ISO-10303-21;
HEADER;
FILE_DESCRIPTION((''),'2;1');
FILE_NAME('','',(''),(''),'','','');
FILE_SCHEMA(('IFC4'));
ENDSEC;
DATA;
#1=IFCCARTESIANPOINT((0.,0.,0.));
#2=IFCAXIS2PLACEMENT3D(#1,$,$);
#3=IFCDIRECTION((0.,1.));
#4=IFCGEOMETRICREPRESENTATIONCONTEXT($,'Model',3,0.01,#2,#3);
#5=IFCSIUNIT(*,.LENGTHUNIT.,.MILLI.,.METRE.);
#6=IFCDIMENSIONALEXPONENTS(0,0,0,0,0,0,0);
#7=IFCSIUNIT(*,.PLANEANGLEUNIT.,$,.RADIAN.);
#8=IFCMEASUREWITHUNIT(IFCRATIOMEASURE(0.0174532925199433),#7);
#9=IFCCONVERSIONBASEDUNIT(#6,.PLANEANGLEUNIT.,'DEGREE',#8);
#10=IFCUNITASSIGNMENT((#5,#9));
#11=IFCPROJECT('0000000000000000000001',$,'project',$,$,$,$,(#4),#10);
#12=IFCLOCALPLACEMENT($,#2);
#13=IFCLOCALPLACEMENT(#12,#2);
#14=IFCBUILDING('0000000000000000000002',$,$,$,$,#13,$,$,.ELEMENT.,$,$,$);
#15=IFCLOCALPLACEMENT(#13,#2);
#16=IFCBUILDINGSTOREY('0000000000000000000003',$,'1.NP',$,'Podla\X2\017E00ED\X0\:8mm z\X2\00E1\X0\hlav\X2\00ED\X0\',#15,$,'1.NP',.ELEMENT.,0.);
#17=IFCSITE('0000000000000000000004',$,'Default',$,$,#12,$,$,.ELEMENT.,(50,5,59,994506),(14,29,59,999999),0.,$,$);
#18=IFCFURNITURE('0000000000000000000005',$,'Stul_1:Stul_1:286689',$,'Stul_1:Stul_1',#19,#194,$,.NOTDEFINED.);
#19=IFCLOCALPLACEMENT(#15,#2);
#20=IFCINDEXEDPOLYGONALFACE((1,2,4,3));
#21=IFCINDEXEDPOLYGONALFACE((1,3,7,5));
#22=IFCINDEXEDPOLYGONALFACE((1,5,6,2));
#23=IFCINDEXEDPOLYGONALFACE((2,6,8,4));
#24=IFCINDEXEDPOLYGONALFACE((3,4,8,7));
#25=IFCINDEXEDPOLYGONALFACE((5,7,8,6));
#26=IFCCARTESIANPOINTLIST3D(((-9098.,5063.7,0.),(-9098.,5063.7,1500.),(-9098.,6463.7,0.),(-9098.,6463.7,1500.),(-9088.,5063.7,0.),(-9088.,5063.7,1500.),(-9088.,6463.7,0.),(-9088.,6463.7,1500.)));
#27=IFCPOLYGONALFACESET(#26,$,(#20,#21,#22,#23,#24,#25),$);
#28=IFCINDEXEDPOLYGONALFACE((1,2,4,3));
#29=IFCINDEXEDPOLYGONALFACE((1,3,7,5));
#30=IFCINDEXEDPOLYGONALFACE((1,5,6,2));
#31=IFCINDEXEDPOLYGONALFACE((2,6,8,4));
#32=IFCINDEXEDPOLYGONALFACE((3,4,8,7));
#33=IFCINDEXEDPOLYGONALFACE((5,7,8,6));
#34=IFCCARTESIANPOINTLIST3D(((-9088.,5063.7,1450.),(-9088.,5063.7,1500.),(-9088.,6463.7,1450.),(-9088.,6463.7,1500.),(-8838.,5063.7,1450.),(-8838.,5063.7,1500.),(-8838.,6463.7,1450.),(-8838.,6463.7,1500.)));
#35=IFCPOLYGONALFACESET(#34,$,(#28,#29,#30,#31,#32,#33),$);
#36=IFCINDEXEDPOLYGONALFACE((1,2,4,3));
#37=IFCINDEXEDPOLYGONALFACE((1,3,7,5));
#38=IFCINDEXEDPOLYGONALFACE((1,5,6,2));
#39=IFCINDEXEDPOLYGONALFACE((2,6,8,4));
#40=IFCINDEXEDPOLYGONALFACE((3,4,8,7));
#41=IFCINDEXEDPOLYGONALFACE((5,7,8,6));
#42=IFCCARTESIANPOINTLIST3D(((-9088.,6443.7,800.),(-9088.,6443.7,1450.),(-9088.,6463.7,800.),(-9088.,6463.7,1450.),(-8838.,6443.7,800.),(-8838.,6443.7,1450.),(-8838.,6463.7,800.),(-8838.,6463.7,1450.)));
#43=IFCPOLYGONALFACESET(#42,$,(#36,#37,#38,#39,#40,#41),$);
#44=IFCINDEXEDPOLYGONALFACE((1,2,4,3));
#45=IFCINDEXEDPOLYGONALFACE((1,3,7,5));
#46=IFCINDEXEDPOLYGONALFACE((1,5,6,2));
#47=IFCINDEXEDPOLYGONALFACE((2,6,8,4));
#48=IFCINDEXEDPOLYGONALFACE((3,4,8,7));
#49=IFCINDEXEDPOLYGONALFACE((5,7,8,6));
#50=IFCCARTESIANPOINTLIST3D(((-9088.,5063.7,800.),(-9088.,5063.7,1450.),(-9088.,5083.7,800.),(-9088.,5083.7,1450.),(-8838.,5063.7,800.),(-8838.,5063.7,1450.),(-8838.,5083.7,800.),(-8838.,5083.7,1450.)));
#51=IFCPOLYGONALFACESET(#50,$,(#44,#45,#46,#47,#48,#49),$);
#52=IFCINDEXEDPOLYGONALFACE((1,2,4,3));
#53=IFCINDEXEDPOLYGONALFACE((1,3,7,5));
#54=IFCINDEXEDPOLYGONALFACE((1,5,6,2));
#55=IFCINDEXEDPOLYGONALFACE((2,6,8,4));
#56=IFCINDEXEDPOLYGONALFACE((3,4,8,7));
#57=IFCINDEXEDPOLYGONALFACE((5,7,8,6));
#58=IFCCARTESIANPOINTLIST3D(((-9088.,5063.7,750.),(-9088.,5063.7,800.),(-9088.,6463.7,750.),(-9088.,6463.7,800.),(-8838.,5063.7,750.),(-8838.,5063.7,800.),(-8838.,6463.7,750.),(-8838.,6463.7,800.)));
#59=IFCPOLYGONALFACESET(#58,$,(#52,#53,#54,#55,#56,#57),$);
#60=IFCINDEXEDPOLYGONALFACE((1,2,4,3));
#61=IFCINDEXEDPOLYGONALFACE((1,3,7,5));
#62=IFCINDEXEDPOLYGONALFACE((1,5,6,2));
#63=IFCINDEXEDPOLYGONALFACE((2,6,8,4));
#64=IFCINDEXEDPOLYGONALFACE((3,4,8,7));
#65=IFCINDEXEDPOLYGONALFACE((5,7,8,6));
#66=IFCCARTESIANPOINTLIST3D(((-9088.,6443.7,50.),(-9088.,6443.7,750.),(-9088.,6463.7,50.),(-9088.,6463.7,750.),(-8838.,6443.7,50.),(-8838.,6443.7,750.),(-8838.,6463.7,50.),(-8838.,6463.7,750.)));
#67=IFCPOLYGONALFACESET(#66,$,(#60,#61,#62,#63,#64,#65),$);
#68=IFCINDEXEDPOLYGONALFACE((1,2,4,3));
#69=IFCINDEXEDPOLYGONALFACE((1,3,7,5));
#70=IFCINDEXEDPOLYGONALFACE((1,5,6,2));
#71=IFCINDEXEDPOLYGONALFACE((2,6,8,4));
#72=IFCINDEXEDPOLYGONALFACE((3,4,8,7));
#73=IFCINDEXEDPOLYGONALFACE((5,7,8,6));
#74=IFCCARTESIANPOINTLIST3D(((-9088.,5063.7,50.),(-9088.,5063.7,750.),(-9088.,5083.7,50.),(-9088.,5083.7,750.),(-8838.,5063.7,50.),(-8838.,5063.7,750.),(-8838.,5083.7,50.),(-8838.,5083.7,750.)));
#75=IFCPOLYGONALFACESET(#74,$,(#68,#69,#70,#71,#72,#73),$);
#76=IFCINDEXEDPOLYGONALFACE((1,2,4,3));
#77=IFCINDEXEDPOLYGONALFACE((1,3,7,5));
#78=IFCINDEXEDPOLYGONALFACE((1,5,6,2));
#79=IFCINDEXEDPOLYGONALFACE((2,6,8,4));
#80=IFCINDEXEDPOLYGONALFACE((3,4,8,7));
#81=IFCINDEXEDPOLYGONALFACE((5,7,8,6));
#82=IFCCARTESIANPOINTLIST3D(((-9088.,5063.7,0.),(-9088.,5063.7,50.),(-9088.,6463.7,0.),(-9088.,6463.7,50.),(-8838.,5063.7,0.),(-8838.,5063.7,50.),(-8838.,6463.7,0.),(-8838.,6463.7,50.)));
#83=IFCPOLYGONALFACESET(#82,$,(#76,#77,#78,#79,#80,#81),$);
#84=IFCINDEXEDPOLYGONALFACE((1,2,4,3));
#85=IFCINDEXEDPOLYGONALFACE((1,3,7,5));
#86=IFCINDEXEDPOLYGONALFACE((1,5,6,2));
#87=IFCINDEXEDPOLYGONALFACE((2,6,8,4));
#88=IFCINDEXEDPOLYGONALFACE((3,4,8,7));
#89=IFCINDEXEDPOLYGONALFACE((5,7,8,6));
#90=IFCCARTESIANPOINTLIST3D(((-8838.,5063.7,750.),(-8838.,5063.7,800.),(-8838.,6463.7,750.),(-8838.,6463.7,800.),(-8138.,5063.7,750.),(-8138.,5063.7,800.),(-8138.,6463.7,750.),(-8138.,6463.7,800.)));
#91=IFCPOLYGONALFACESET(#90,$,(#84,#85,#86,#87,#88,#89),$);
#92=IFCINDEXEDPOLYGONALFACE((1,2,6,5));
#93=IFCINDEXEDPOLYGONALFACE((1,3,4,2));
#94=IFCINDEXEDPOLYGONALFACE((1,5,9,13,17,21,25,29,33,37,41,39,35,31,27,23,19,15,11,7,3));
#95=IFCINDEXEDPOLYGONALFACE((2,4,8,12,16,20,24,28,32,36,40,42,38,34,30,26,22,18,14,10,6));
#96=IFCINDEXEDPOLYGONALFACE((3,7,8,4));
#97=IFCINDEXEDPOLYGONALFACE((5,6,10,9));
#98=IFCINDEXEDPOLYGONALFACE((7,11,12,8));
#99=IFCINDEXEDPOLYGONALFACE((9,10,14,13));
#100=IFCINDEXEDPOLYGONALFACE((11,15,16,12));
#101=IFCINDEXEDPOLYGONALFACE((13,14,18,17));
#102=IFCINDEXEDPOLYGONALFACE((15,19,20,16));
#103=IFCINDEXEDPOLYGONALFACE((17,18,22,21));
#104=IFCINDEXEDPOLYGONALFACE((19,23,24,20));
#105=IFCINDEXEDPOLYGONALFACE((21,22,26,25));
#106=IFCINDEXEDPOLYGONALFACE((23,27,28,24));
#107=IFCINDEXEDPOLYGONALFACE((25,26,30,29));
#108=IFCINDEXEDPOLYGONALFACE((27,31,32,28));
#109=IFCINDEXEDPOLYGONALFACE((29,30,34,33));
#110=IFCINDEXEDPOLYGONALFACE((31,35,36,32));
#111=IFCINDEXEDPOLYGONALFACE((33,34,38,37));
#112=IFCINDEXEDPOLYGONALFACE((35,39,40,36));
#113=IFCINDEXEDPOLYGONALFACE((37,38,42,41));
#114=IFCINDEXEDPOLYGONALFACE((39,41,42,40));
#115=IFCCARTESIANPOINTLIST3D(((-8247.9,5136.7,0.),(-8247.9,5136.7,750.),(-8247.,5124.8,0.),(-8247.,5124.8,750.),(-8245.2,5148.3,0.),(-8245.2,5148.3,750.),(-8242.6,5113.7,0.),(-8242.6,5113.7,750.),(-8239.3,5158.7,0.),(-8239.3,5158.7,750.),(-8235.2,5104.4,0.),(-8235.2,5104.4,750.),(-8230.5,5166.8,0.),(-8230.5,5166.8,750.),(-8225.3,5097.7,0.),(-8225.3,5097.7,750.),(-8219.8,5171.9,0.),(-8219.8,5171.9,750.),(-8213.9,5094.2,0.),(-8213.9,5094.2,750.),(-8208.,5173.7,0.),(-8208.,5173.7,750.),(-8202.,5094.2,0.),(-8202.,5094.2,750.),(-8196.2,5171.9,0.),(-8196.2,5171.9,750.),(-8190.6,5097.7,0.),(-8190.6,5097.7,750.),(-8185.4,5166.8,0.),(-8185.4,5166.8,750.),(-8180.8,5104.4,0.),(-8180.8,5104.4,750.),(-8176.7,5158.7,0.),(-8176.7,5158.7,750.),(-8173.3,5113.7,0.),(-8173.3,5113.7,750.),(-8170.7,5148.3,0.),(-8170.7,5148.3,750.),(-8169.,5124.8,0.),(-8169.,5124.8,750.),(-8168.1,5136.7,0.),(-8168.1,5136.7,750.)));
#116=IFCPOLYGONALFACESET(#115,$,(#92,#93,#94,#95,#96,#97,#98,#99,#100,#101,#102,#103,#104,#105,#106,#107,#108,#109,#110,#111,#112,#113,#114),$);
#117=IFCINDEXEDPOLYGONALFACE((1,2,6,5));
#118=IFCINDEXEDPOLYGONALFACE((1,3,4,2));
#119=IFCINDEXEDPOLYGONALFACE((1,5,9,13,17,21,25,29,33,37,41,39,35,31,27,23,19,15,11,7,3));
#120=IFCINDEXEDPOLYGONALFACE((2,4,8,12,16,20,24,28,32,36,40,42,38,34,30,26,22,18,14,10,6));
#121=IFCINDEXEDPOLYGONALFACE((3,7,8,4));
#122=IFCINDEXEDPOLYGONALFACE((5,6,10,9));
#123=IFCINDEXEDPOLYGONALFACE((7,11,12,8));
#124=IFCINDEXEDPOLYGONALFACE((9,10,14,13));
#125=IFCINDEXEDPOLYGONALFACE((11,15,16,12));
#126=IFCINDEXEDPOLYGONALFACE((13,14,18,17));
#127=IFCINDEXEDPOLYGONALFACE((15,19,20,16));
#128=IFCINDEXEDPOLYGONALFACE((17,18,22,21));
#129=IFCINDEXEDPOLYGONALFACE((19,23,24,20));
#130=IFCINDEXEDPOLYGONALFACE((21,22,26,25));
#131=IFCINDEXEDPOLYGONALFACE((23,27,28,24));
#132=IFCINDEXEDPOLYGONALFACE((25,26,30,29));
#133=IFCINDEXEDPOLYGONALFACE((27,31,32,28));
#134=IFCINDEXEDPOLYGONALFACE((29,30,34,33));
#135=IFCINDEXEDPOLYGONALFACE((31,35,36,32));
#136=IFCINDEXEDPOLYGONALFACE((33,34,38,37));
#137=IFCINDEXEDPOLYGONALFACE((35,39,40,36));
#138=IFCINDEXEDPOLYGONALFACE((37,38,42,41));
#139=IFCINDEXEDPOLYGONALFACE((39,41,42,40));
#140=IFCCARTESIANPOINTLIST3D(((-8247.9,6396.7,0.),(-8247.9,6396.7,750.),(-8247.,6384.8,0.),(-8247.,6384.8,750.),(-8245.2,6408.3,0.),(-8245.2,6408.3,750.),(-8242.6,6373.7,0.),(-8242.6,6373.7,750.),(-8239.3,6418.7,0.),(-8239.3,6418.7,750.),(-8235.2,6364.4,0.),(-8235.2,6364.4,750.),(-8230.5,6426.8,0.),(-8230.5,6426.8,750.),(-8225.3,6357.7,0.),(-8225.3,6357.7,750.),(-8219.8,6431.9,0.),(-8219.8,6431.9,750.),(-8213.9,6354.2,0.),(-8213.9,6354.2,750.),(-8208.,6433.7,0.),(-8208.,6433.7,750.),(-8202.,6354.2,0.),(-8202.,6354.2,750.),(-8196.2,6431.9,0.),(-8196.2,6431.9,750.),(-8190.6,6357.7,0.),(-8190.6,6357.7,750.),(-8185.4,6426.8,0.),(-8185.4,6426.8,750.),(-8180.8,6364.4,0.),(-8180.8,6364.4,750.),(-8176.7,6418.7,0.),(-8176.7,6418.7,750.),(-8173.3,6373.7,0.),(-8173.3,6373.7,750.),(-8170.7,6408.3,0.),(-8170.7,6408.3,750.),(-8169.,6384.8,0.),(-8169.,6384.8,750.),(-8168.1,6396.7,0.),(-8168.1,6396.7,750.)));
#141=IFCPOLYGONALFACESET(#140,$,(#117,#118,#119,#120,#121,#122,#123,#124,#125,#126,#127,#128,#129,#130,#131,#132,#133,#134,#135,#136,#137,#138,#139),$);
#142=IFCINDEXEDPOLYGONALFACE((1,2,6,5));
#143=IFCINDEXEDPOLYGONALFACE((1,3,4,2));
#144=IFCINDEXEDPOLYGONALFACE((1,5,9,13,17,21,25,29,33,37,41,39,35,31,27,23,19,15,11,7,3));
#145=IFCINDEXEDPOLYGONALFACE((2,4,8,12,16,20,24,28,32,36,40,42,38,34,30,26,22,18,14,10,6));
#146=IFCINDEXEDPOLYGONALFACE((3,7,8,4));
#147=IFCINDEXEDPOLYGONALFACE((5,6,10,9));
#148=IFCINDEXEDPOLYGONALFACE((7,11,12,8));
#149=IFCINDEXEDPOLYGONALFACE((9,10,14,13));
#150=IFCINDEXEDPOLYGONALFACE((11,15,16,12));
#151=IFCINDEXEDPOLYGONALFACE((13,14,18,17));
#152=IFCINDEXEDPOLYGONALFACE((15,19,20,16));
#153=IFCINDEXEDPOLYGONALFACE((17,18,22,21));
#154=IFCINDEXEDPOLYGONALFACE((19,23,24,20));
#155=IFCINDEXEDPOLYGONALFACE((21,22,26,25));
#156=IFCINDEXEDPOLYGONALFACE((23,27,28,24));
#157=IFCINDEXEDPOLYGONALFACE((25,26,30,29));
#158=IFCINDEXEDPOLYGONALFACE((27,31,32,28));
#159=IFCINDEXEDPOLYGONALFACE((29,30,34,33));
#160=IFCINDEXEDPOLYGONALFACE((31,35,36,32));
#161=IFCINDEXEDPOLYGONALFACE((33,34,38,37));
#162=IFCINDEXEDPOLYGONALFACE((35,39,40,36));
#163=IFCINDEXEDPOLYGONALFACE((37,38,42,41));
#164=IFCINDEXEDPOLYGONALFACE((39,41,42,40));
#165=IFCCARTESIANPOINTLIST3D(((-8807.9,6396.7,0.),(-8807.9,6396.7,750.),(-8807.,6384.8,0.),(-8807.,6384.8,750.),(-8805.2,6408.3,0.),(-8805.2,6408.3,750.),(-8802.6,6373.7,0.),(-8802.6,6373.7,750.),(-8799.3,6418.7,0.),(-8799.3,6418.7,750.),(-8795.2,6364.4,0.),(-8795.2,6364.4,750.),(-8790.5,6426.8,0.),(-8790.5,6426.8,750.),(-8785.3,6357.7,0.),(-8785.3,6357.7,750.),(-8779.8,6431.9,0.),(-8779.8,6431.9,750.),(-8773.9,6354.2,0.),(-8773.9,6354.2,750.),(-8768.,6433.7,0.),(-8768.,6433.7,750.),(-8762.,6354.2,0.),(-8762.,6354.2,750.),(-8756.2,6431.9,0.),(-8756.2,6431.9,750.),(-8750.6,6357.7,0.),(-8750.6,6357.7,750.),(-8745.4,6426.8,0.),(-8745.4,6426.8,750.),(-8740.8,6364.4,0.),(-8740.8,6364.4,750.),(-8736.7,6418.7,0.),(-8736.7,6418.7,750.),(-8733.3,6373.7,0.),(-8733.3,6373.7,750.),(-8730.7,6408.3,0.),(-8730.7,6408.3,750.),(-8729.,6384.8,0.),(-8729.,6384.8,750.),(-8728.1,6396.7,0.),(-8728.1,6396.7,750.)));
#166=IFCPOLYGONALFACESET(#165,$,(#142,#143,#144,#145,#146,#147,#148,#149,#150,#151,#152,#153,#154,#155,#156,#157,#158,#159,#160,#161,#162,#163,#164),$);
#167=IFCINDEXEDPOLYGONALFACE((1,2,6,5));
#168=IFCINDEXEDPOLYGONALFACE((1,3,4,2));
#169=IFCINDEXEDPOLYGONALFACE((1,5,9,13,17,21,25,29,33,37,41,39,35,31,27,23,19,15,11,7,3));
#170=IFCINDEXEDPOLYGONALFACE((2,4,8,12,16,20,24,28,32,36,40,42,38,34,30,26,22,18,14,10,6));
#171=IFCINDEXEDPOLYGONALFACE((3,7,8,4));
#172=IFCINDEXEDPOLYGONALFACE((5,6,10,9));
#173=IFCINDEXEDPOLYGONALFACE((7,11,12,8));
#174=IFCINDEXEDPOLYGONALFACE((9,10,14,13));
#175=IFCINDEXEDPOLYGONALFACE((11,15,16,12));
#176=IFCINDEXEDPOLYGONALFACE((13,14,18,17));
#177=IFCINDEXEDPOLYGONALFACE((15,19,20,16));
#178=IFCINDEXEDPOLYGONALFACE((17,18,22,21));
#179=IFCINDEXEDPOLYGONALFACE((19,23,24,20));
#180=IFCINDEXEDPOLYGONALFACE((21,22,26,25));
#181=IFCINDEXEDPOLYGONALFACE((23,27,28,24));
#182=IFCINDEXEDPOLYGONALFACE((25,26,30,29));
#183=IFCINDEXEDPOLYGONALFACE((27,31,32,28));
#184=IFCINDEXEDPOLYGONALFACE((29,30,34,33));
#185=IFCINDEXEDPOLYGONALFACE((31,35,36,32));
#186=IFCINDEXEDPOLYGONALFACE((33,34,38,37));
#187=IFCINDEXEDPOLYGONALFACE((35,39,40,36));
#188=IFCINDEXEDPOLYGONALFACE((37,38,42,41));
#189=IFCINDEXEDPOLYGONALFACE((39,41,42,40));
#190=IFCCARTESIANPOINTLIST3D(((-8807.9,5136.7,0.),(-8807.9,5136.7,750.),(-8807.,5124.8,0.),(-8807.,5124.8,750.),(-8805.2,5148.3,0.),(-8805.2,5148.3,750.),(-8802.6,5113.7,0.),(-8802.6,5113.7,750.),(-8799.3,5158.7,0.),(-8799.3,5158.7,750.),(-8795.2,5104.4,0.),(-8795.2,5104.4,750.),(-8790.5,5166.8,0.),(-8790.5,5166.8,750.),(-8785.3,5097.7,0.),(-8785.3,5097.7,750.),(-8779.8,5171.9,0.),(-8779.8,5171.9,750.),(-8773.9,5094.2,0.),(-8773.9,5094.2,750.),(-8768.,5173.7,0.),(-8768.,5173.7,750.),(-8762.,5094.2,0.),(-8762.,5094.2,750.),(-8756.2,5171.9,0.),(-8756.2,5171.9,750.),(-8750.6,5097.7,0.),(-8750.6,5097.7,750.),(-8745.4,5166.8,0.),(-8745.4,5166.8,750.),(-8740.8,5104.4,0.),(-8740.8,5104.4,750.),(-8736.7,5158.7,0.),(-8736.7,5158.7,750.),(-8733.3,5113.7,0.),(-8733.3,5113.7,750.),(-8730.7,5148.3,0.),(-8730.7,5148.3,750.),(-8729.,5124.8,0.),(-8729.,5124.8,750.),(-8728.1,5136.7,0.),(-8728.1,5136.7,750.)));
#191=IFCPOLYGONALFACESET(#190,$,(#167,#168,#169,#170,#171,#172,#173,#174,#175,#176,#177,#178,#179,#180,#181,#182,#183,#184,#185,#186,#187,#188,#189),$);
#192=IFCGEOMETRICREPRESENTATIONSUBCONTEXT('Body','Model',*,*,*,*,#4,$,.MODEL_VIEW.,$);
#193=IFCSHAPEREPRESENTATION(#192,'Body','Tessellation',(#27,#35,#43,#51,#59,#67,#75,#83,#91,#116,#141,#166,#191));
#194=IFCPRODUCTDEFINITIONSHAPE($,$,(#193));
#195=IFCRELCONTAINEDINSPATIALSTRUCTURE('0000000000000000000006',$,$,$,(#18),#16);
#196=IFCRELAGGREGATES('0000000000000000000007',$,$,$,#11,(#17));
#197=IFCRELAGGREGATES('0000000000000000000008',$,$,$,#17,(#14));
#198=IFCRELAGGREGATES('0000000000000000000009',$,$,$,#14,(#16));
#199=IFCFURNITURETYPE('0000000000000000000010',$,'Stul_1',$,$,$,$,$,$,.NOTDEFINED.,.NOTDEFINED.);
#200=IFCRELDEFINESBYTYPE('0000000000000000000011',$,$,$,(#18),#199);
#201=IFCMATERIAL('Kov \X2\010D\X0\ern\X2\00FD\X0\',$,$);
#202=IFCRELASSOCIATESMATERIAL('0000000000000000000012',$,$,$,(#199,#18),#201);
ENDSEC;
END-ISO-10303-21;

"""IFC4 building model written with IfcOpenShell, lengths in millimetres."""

from ifc_helpers import new_model, entity, si_unit, converted_unit, direction, frame, frame_2d, origin, origin_2d_with_axis, place, context, subcontext, project, spatial, rectangle, circle, extrude, source, transform, mapped, material, type_object, type_shapes, element, save


model = new_model("IFC4")

# Units and contexts
model_context = context("Model", 3, precision=0.01, world=origin(), true_north=direction((0.0, 1.0)))
body_context = subcontext(model_context, "Body", "Model", "MODEL_VIEW")
ifc_project = project(units=[si_unit("LENGTHUNIT", "METRE", prefix="MILLI"), converted_unit("PLANEANGLEUNIT", "DEGREE", entity("IfcRatioMeasure", 0.0174532925199433), si_unit("PLANEANGLEUNIT", "RADIAN"), dimensions=[0, 0, 0, 0, 0, 0, 0])], contexts=[model_context])

# Site, building, storey
site_placement = place(None, origin())
site = spatial("IfcSite", under=ifc_project, at=site_placement, Name="Default", CompositionType="ELEMENT", RefLatitude=(50, 5, 59, 994506), RefLongitude=(14, 29, 59, 999999), RefElevation=0.0)
building_placement = place(site_placement, origin())
building = spatial("IfcBuilding", under=site, at=building_placement, CompositionType="ELEMENT")
storey_placement = place(building_placement, origin())
storey = spatial("IfcBuildingStorey", under=building, at=storey_placement, Name="1.NP", ObjectType="Podlaží:8mm záhlaví", LongName="1.NP", CompositionType="ELEMENT", Elevation=0.0)

# Furniture
ifc_material_1 = material(Name="Kov černý")
furniture_type = type_object("IfcFurnitureType", Name="Stul_1", AssemblyPlace="NOTDEFINED", PredefinedType="NOTDEFINED", material=ifc_material_1)
shared_shape_1 = source(origin(), body_context, "Body", "SweptSolid", [
    extrude(rectangle(XDim=1400.0, YDim=10.0, at=origin_2d_with_axis()), frame((0.0, 605.0, 0.0), z_axis=(0.0, 0.0, 1.0), x_axis=(-1.0, 0.0, 0.0)), (0.0, 0.0, 1.0), 1500.0),
    extrude(rectangle(XDim=1400.0, YDim=250.0, at=frame_2d((0.0, 0.0), x_axis=(1.0, 0.0))), frame((0.0, 475.0, 1450.0), z_axis=(0.0, 0.0, 1.0), x_axis=(-1.0, 0.0, 0.0)), (0.0, 0.0, 1.0), 50.0),
    extrude(rectangle(XDim=20.0, YDim=250.0, at=origin_2d_with_axis()), frame((690.0, 475.0, 800.0), z_axis=(0.0, 0.0, 1.0), x_axis=(-1.0, 0.0, 0.0)), (0.0, 0.0, 1.0), 650.0),
    extrude(rectangle(XDim=20.0, YDim=250.0, at=frame_2d((0.0, 0.0), x_axis=(1.0, 0.0))), frame((-690.0, 475.0, 800.0), z_axis=(0.0, 0.0, 1.0), x_axis=(-1.0, 0.0, 0.0)), (0.0, 0.0, 1.0), 650.0),
    extrude(rectangle(XDim=1400.0, YDim=250.0, at=origin_2d_with_axis()), frame((0.0, 475.0, 750.0), z_axis=(0.0, 0.0, 1.0), x_axis=(-1.0, 0.0, 0.0)), (0.0, 0.0, 1.0), 50.0),
    extrude(rectangle(XDim=20.0, YDim=250.0, at=origin_2d_with_axis()), frame((690.0, 475.0, 50.0), z_axis=(0.0, 0.0, 1.0), x_axis=(-1.0, 0.0, 0.0)), (0.0, 0.0, 1.0), 700.0),
    extrude(rectangle(XDim=20.0, YDim=250.0, at=frame_2d((0.0, 0.0), x_axis=(1.0, 0.0))), frame((-690.0, 475.0, 50.0), z_axis=(0.0, 0.0, 1.0), x_axis=(-1.0, 0.0, 0.0)), (0.0, 0.0, 1.0), 700.0),
    extrude(rectangle(XDim=1400.0, YDim=250.0, at=origin_2d_with_axis()), frame((0.0, 475.0, 0.0), z_axis=(0.0, 0.0, 1.0), x_axis=(-1.0, 0.0, 0.0)), (0.0, 0.0, 1.0), 50.0),
    extrude(rectangle(XDim=1400.0, YDim=700.0, at=origin_2d_with_axis()), frame((0.0, 0.0, 750.0), z_axis=(0.0, 0.0, 1.0), x_axis=(-1.0, 0.0, 0.0)), (0.0, 0.0, 1.0), 50.0),
    extrude(circle(Radius=40.0, at=frame_2d((0.0, 0.0), x_axis=(1.0, 0.0))), frame((-630.0, -280.0, 0.0)), (0.0, 0.0, 1.0), 750.0),
    extrude(circle(Radius=40.0, at=frame_2d((0.0, 0.0), x_axis=(1.0, 0.0))), frame((630.0, -280.0, 0.0)), (0.0, 0.0, 1.0), 750.0),
    extrude(circle(Radius=40.0, at=frame_2d((0.0, 0.0), x_axis=(1.0, 0.0))), frame((630.0, 280.0, 0.0)), (0.0, 0.0, 1.0), 750.0),
    extrude(circle(Radius=40.0, at=frame_2d((0.0, 0.0), x_axis=(1.0, 0.0))), frame((-630.0, 280.0, 0.0)), (0.0, 0.0, 1.0), 750.0),
])
type_shapes(furniture_type, [shared_shape_1])
for number, where, z_axis, x_axis, name in (
    (1, (-8488.0, 5763.7, 0.0), (0.0, 0.0, 1.0), (0.0, 1.0, 0.0), "Stul_1:Stul_1:286689"),
):
    element("IfcFurniture", number, at=place(storey_placement, frame(where, z_axis=z_axis, x_axis=x_axis)), inside=storey, type_object=furniture_type, material=ifc_material_1, Name=name, ObjectType="Stul_1:Stul_1", PredefinedType="NOTDEFINED", context=body_context, shape_type="MappedRepresentation", body=[
        mapped(shared_shape_1, transform((0.0, 0.0, 0.0), scale=1.0)),
    ])

save(model, "model.ifc")
